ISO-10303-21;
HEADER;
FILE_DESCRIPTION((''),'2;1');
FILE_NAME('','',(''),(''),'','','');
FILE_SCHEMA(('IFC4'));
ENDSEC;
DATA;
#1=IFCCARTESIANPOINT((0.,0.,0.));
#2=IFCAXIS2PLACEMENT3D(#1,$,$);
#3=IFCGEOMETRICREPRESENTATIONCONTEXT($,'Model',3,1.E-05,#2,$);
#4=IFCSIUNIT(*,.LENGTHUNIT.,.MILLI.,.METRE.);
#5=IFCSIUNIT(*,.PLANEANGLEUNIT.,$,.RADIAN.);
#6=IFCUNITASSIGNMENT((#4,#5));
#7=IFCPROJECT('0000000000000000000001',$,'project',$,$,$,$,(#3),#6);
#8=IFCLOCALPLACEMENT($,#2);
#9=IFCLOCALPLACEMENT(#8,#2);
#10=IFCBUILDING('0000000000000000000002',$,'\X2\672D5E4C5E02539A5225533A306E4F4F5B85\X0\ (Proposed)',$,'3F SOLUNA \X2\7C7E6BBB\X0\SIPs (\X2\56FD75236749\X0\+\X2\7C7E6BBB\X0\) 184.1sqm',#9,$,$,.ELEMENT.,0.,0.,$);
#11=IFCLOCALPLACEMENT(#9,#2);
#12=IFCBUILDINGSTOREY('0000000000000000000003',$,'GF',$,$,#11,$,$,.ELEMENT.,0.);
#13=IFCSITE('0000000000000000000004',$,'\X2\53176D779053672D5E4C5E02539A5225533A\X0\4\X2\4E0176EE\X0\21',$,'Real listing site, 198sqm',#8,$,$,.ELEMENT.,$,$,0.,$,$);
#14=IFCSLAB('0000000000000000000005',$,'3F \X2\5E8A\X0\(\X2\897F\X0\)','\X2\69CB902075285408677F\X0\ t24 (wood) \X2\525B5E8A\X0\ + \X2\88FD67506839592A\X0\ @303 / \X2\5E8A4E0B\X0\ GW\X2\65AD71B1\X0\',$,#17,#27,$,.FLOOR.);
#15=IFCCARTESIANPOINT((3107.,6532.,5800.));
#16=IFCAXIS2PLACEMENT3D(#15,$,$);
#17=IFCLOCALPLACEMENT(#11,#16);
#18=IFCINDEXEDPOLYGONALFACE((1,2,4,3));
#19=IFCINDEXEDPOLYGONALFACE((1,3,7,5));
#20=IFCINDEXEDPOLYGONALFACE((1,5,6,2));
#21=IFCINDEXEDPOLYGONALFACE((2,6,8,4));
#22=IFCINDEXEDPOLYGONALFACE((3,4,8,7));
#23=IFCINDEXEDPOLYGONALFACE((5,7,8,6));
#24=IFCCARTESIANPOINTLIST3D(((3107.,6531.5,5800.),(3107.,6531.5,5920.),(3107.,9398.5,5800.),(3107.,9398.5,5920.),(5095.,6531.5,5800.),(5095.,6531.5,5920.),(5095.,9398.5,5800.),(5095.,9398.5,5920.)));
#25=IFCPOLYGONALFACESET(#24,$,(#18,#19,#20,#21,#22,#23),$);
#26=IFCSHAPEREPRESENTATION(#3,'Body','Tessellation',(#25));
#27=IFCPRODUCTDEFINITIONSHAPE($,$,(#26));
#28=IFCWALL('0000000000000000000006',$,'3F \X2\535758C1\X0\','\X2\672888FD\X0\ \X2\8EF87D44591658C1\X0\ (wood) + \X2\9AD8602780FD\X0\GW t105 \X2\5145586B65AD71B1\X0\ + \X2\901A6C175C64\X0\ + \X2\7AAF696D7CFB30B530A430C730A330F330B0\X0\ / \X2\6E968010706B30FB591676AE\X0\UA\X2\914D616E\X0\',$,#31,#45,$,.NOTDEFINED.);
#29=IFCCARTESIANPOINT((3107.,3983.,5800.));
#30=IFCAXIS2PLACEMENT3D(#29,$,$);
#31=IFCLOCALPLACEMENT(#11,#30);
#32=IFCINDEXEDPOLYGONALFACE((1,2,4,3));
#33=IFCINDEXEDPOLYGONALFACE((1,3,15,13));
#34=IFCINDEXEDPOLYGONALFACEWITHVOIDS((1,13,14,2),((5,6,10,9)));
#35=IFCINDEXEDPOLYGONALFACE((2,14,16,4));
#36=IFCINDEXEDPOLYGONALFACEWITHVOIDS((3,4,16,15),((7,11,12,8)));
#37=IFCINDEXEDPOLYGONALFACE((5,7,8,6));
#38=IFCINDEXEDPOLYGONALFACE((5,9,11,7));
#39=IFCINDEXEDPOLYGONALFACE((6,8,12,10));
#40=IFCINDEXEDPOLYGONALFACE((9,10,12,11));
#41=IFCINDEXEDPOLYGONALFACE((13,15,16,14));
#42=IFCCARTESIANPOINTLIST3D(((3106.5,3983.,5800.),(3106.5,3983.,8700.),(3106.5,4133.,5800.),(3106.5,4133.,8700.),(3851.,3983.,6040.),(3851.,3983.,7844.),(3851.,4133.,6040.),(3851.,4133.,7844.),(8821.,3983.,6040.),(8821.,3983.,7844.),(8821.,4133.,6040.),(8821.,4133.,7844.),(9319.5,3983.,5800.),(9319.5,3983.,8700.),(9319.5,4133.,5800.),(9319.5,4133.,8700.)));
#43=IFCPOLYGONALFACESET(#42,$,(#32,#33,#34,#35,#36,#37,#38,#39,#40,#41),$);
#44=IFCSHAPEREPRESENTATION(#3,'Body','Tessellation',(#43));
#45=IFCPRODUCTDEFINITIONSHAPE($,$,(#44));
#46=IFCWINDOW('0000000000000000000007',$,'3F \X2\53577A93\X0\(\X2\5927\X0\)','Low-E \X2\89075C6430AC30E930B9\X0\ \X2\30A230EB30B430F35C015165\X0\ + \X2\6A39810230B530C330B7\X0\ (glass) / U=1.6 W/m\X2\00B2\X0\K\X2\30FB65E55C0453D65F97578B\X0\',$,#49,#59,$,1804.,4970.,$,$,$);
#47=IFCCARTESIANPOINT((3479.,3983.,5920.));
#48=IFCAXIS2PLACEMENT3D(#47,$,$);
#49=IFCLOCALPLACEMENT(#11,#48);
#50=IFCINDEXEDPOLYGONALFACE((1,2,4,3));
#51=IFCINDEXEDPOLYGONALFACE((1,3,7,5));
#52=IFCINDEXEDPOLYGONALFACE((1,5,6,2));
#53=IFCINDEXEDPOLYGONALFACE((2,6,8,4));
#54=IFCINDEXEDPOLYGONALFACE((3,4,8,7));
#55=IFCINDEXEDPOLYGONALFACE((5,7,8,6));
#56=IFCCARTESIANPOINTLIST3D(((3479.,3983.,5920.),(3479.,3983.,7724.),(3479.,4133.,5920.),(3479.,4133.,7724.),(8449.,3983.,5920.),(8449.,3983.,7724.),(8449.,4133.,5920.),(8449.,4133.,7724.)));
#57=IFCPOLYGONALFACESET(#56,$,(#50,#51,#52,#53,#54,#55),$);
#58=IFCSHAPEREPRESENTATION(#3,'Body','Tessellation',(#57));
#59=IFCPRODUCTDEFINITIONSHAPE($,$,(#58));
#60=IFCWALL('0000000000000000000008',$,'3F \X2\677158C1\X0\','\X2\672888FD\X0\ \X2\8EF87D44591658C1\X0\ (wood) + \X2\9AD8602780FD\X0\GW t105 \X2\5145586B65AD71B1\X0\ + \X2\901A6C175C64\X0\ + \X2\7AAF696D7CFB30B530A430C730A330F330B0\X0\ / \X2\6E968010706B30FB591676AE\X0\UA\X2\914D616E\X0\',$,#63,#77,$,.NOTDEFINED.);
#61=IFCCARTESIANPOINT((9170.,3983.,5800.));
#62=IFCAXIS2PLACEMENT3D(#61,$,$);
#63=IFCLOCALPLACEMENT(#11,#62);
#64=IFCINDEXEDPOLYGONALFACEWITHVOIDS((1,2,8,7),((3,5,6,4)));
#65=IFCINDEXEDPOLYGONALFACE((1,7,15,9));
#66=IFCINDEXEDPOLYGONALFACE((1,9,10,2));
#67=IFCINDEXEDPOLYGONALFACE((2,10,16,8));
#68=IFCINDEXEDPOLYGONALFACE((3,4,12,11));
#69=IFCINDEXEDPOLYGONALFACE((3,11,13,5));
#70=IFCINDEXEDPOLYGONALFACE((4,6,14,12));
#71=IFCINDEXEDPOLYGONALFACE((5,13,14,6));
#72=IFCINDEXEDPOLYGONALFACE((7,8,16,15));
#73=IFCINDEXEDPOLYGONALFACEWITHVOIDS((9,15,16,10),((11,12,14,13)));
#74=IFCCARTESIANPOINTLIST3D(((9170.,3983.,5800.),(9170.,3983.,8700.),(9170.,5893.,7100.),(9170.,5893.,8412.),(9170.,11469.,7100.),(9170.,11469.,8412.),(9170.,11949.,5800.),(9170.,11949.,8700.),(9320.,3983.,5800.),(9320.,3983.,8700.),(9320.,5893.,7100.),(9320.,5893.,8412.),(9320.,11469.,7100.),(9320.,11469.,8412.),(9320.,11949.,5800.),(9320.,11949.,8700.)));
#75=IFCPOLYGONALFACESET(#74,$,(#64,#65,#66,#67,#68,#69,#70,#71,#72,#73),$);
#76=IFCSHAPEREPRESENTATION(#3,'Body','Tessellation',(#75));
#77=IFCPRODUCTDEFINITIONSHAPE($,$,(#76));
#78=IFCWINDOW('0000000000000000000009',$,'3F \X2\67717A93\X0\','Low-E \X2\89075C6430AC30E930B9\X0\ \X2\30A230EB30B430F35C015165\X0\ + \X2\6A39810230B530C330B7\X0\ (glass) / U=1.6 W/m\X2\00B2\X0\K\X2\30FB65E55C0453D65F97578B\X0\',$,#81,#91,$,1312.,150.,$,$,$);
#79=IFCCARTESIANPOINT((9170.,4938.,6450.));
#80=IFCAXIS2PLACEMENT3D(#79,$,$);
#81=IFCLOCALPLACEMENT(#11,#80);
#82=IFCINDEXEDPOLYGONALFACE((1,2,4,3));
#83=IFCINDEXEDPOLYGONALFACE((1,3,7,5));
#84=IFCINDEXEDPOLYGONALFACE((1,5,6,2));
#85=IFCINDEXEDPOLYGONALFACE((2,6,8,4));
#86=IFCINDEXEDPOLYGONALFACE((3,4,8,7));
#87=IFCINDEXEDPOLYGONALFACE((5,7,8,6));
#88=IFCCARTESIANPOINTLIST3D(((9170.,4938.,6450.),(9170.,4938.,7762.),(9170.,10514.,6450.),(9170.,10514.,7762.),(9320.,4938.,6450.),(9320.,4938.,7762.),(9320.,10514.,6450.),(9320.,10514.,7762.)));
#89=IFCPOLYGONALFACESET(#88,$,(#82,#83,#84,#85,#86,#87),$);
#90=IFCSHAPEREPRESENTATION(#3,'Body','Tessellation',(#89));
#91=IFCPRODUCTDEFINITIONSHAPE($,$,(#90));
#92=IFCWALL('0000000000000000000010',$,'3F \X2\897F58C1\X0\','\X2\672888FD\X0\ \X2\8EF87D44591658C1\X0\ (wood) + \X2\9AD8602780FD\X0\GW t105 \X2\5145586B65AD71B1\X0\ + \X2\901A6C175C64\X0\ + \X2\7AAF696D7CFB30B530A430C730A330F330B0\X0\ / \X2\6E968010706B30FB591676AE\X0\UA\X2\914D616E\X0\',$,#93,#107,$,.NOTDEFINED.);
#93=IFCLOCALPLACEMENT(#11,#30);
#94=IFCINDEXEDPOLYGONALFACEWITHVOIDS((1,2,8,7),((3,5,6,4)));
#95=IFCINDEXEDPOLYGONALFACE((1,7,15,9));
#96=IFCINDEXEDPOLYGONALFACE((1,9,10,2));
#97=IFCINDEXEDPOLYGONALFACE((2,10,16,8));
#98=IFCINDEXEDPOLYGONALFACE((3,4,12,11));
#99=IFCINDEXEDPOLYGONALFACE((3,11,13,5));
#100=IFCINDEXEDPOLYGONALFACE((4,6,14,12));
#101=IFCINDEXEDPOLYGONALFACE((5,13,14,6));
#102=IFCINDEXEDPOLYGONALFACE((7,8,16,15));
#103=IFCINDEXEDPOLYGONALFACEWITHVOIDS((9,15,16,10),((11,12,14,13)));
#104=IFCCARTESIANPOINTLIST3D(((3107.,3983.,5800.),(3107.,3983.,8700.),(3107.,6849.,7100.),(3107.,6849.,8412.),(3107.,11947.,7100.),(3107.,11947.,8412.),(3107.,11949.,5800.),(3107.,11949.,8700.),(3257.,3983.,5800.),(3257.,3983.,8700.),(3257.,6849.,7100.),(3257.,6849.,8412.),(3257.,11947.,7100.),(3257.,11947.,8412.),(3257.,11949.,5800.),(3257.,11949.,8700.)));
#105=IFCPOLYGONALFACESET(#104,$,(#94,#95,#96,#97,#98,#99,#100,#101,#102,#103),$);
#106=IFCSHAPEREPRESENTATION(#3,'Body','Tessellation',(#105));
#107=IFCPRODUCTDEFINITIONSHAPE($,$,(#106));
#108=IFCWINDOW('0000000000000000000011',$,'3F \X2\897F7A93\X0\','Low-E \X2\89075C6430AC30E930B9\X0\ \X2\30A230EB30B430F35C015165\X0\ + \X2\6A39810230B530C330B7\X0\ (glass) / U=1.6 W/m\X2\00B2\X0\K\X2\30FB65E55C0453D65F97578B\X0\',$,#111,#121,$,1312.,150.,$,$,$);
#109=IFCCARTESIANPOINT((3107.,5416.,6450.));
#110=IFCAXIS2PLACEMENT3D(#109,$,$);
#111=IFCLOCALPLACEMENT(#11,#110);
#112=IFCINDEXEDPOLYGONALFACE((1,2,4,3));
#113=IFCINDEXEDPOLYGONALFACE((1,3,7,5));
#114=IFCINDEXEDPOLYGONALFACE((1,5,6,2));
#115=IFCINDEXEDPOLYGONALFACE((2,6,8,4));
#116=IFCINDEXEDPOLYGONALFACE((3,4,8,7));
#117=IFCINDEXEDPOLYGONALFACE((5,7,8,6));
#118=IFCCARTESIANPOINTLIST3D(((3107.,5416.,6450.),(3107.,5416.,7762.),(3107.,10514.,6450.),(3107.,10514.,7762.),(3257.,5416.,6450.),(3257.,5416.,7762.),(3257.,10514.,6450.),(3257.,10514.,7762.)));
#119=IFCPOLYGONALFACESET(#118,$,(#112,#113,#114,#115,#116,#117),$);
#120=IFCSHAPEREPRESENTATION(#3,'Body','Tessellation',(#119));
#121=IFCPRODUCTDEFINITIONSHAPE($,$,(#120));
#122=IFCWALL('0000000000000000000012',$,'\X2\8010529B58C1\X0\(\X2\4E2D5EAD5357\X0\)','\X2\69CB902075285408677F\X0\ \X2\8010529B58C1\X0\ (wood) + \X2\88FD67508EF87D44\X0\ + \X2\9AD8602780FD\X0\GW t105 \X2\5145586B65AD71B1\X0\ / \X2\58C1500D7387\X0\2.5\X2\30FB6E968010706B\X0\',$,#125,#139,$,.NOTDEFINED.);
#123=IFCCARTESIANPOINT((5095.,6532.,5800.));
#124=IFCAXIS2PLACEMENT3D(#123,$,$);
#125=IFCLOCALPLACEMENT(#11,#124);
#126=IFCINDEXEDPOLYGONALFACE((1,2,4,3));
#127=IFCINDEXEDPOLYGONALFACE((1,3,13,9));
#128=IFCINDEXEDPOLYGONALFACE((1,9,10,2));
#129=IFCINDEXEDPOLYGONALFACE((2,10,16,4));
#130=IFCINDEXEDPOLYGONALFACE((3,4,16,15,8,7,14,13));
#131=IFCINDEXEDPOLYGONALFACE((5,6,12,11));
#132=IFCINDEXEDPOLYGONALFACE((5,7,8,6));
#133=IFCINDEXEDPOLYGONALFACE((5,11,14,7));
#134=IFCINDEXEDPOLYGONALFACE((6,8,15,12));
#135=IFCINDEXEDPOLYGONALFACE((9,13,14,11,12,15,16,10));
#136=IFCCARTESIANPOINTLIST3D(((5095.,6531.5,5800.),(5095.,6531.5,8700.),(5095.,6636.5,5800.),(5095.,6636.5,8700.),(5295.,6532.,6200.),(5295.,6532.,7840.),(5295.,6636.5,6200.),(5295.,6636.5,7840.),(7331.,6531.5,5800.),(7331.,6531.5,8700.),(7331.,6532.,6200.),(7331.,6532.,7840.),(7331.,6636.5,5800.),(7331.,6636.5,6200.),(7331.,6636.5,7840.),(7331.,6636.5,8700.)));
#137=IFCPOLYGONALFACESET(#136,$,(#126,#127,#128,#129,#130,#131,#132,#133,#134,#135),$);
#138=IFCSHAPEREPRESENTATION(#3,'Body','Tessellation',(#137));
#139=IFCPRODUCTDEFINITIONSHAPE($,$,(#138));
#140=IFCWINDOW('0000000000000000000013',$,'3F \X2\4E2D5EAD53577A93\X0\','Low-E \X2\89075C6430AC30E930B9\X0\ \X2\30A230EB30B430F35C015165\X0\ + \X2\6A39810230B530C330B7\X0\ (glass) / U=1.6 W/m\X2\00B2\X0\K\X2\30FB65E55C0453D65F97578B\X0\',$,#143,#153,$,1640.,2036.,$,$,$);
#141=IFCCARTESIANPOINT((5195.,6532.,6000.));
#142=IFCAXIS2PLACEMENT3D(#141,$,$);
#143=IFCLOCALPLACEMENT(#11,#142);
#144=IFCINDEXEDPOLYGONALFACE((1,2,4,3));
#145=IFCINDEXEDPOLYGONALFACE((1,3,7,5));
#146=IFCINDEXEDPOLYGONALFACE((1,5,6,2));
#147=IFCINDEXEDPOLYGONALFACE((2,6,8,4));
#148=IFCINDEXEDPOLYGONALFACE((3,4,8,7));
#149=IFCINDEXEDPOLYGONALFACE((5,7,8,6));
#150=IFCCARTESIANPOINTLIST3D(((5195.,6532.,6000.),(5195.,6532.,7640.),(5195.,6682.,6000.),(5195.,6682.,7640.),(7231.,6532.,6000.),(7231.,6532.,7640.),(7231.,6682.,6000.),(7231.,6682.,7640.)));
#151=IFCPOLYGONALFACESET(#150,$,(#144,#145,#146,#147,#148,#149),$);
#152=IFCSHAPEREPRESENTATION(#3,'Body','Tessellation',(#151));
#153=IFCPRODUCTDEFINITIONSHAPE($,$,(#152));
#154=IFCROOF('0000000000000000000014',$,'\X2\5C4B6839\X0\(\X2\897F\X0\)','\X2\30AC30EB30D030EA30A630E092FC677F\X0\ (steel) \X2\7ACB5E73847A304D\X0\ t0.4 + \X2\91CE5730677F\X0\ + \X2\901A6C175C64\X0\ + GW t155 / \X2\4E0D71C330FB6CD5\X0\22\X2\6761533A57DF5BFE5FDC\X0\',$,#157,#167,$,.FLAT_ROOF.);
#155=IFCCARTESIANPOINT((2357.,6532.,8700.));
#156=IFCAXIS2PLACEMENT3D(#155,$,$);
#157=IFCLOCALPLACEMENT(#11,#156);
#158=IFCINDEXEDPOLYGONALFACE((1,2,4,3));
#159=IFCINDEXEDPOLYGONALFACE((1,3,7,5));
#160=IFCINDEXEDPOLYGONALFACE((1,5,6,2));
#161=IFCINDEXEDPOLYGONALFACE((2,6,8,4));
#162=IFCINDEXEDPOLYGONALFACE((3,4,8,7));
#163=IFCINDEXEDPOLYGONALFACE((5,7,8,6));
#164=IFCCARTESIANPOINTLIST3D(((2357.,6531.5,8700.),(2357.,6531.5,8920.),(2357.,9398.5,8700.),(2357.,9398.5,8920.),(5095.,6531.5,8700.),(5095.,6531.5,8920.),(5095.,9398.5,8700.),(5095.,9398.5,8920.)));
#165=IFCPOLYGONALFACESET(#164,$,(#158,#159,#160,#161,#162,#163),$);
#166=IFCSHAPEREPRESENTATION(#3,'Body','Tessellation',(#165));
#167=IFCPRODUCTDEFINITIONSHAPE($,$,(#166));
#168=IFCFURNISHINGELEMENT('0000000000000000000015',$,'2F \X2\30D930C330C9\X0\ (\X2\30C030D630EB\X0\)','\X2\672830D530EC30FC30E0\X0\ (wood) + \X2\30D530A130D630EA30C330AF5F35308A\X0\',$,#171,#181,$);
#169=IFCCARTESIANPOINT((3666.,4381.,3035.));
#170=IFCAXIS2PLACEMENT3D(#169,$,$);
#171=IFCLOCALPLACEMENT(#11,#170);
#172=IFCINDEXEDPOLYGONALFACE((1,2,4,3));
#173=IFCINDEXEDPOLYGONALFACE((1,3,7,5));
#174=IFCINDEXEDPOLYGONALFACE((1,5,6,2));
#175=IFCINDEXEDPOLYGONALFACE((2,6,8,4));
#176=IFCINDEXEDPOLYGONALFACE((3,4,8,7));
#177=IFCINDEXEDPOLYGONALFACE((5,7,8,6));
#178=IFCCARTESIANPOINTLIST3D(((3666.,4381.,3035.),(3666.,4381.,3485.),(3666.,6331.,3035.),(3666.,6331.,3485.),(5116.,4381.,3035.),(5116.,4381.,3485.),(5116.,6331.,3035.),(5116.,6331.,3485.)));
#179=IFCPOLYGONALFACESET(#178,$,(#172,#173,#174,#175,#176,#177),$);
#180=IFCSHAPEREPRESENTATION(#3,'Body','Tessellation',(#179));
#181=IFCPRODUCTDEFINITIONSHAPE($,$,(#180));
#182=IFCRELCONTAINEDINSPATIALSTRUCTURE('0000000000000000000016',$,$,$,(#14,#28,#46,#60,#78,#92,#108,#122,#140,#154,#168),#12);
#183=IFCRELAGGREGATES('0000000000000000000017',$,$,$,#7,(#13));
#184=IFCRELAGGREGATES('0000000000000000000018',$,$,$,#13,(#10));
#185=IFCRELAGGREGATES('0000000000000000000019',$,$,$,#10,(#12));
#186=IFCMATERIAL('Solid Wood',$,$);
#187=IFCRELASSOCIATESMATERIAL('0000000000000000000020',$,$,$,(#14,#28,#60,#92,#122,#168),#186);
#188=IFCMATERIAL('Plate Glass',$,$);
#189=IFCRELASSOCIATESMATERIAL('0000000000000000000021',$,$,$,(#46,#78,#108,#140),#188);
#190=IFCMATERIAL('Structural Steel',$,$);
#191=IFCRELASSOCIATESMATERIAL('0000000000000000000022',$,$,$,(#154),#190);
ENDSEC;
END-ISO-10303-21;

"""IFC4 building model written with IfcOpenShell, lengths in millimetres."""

from ifc_helpers import new_model, si_unit, frame, frame_2d, origin, place, context, project, spatial, rectangle, extrude, material, element, fill, save


model = new_model("IFC4")

# Units and contexts
model_context = context("Model", 3, precision=1e-05, world=origin())
ifc_project = project(units=[si_unit("LENGTHUNIT", "METRE", prefix="MILLI"), si_unit("PLANEANGLEUNIT", "RADIAN")], contexts=[model_context])

# Site, building, storey
site_placement = place(None, origin())
site = spatial("IfcSite", under=ifc_project, at=site_placement, Name="北海道札幌市厚別区4丁目21", ObjectType="Real listing site, 198sqm", CompositionType="ELEMENT", RefElevation=0.0)
building_placement = place(site_placement, origin())
building = spatial("IfcBuilding", under=site, at=building_placement, Name="札幌市厚別区の住宅 (Proposed)", ObjectType="3F SOLUNA 籾殻SIPs (国産杉+籾殻) 184.1sqm", CompositionType="ELEMENT", ElevationOfRefHeight=0.0, ElevationOfTerrain=0.0)
storey_placement = place(building_placement, origin())
storey = spatial("IfcBuildingStorey", under=building, at=storey_placement, Name="GF", CompositionType="ELEMENT", Elevation=0.0)

# Slab
ifc_material_1 = material(Name="Solid Wood")
slab_1_placement = place(storey_placement, frame((3107.0, 6532.0, 5800.0)))
element("IfcSlab", 1, at=slab_1_placement, inside=storey, material=ifc_material_1, Name="3F 床(西)", Description="構造用合板 t24 (wood) 剛床 + 製材根太 @303 / 床下 GW断熱", PredefinedType="FLOOR", context=model_context, shape_type="SweptSolid", body=[
    extrude(rectangle(XDim=1988.0, YDim=2867.0, at=frame_2d((994.0, 1433.0))), frame((3107.0, 6532.0, 5800.0)), (0.0, 0.0, 1.0), 120.0),
])

# Walls, openings, windows
wall_1_placement = place(storey_placement, frame((3107.0, 3983.0, 5800.0)))
wall_1 = element("IfcWall", 2, at=wall_1_placement, inside=storey, material=ifc_material_1, Name="3F 南壁", Description="木製 軸組外壁 (wood) + 高性能GW t105 充填断熱 + 通気層 + 窯業系サイディング / 準耐火・外皮UA配慮", PredefinedType="NOTDEFINED", context=model_context, shape_type="SweptSolid", body=[
    extrude(rectangle(XDim=6213.0, YDim=150.0, at=frame_2d((3106.0, 75.0))), frame((3107.0, 3983.0, 5800.0)), (0.0, 0.0, 1.0), 2900.0),
])
opening_1_placement = place(storey_placement, frame((3479.0, 3983.0, 5920.0)))
opening_1 = element("IfcOpeningElement", 3, at=opening_1_placement, cuts=wall_1, PredefinedType="NOTDEFINED", context=model_context, shape_type="SweptSolid", body=[
    extrude(rectangle(XDim=4970.0, YDim=150.0, at=frame_2d((2485.0, 75.0))), frame((3479.0, 3983.0, 5920.0)), (0.0, 0.0, 1.0), 1804.0),
])
ifc_material_2 = material(Name="Plate Glass")
window_1_placement = place(storey_placement, frame((3479.0, 3983.0, 5920.0)))
window_1 = element("IfcWindow", 4, at=window_1_placement, inside=storey, material=ifc_material_2, Name="3F 南窓(大)", Description="Low-E 複層ガラス アルゴン封入 + 樹脂サッシ (glass) / U=1.6 W/m²K・日射取得型", OverallHeight=1804.0, OverallWidth=4970.0, context=model_context, shape_type="SweptSolid", body=[
    extrude(rectangle(XDim=4970.0, YDim=150.0, at=frame_2d((2485.0, 75.0))), frame((3479.0, 3983.0, 5920.0)), (0.0, 0.0, 1.0), 1804.0),
])
fill(opening_1, window_1)
wall_2_placement = place(storey_placement, frame((9170.0, 3983.0, 5800.0)))
wall_2 = element("IfcWall", 5, at=wall_2_placement, inside=storey, material=ifc_material_1, Name="3F 東壁", Description="木製 軸組外壁 (wood) + 高性能GW t105 充填断熱 + 通気層 + 窯業系サイディング / 準耐火・外皮UA配慮", PredefinedType="NOTDEFINED", context=model_context, shape_type="SweptSolid", body=[
    extrude(rectangle(XDim=150.0, YDim=7966.0, at=frame_2d((75.0, 3983.0))), frame((9170.0, 3983.0, 5800.0)), (0.0, 0.0, 1.0), 2900.0),
])
opening_2_placement = place(storey_placement, frame((9170.0, 4938.0, 6450.0)))
opening_2 = element("IfcOpeningElement", 6, at=opening_2_placement, cuts=wall_2, PredefinedType="NOTDEFINED", context=model_context, shape_type="SweptSolid", body=[
    extrude(rectangle(XDim=150.0, YDim=5576.0, at=frame_2d((75.0, 2788.0))), frame((9170.0, 4938.0, 6450.0)), (0.0, 0.0, 1.0), 1312.0),
])
window_2_placement = place(storey_placement, frame((9170.0, 4938.0, 6450.0)))
window_2 = element("IfcWindow", 7, at=window_2_placement, inside=storey, material=ifc_material_2, Name="3F 東窓", Description="Low-E 複層ガラス アルゴン封入 + 樹脂サッシ (glass) / U=1.6 W/m²K・日射取得型", OverallHeight=1312.0, OverallWidth=150.0, context=model_context, shape_type="SweptSolid", body=[
    extrude(rectangle(XDim=150.0, YDim=5576.0, at=frame_2d((75.0, 2788.0))), frame((9170.0, 4938.0, 6450.0)), (0.0, 0.0, 1.0), 1312.0),
])
fill(opening_2, window_2)
wall_3_placement = place(storey_placement, frame((3107.0, 3983.0, 5800.0)))
wall_3 = element("IfcWall", 8, at=wall_3_placement, inside=storey, material=ifc_material_1, Name="3F 西壁", Description="木製 軸組外壁 (wood) + 高性能GW t105 充填断熱 + 通気層 + 窯業系サイディング / 準耐火・外皮UA配慮", PredefinedType="NOTDEFINED", context=model_context, shape_type="SweptSolid", body=[
    extrude(rectangle(XDim=150.0, YDim=7966.0, at=frame_2d((75.0, 3983.0))), frame((3107.0, 3983.0, 5800.0)), (0.0, 0.0, 1.0), 2900.0),
])
opening_3_placement = place(storey_placement, frame((3107.0, 5416.0, 6450.0)))
opening_3 = element("IfcOpeningElement", 9, at=opening_3_placement, cuts=wall_3, PredefinedType="NOTDEFINED", context=model_context, shape_type="SweptSolid", body=[
    extrude(rectangle(XDim=150.0, YDim=5098.0, at=frame_2d((75.0, 2549.0))), frame((3107.0, 5416.0, 6450.0)), (0.0, 0.0, 1.0), 1312.0),
])
window_3_placement = place(storey_placement, frame((3107.0, 5416.0, 6450.0)))
window_3 = element("IfcWindow", 10, at=window_3_placement, inside=storey, material=ifc_material_2, Name="3F 西窓", Description="Low-E 複層ガラス アルゴン封入 + 樹脂サッシ (glass) / U=1.6 W/m²K・日射取得型", OverallHeight=1312.0, OverallWidth=150.0, context=model_context, shape_type="SweptSolid", body=[
    extrude(rectangle(XDim=150.0, YDim=5098.0, at=frame_2d((75.0, 2549.0))), frame((3107.0, 5416.0, 6450.0)), (0.0, 0.0, 1.0), 1312.0),
])
fill(opening_3, window_3)
wall_4_placement = place(storey_placement, frame((5095.0, 6532.0, 5800.0)))
wall_4 = element("IfcWall", 11, at=wall_4_placement, inside=storey, material=ifc_material_1, Name="耐力壁(中庭南)", Description="構造用合板 耐力壁 (wood) + 製材軸組 + 高性能GW t105 充填断熱 / 壁倍率2.5・準耐火", PredefinedType="NOTDEFINED", context=model_context, shape_type="SweptSolid", body=[
    extrude(rectangle(XDim=2236.0, YDim=105.0, at=frame_2d((1118.0, 52.0))), frame((5095.0, 6532.0, 5800.0)), (0.0, 0.0, 1.0), 2900.0),
])
opening_4_placement = place(storey_placement, frame((5195.0, 6532.0, 6000.0)))
opening_4 = element("IfcOpeningElement", 12, at=opening_4_placement, cuts=wall_4, PredefinedType="NOTDEFINED", context=model_context, shape_type="SweptSolid", body=[
    extrude(rectangle(XDim=2036.0, YDim=150.0, at=frame_2d((1018.0, 75.0))), frame((5195.0, 6532.0, 6000.0)), (0.0, 0.0, 1.0), 1640.0),
])
window_4_placement = place(storey_placement, frame((5195.0, 6532.0, 6000.0)))
window_4 = element("IfcWindow", 13, at=window_4_placement, inside=storey, material=ifc_material_2, Name="3F 中庭南窓", Description="Low-E 複層ガラス アルゴン封入 + 樹脂サッシ (glass) / U=1.6 W/m²K・日射取得型", OverallHeight=1640.0, OverallWidth=2036.0, context=model_context, shape_type="SweptSolid", body=[
    extrude(rectangle(XDim=2036.0, YDim=150.0, at=frame_2d((1018.0, 75.0))), frame((5195.0, 6532.0, 6000.0)), (0.0, 0.0, 1.0), 1640.0),
])
fill(opening_4, window_4)

# Roof
ifc_material_3 = material(Name="Structural Steel")
roof_1_placement = place(storey_placement, frame((2357.0, 6532.0, 8700.0)))
element("IfcRoof", 14, at=roof_1_placement, inside=storey, material=ifc_material_3, Name="屋根(西)", Description="ガルバリウム鋼板 (steel) 立平葺き t0.4 + 野地板 + 通気層 + GW t155 / 不燃・法22条区域対応", PredefinedType="FLAT_ROOF", context=model_context, shape_type="SweptSolid", body=[
    extrude(rectangle(XDim=2738.0, YDim=2867.0, at=frame_2d((1369.0, 1433.0))), frame((2357.0, 6532.0, 8700.0)), (0.0, 0.0, 1.0), 220.0),
])

# Furnishing element
furnishing_1_placement = place(storey_placement, frame((3666.0, 4381.0, 3035.0)))
element("IfcFurnishingElement", 15, at=furnishing_1_placement, inside=storey, material=ifc_material_1, Name="2F ベッド (ダブル)", Description="木フレーム (wood) + ファブリック張り", context=model_context, shape_type="SweptSolid", body=[
    extrude(rectangle(XDim=1450.0, YDim=1950.0, at=frame_2d((725.0, 975.0))), frame((3666.0, 4381.0, 3035.0)), (0.0, 0.0, 1.0), 450.0),
])

save(model, "model.ifc")
